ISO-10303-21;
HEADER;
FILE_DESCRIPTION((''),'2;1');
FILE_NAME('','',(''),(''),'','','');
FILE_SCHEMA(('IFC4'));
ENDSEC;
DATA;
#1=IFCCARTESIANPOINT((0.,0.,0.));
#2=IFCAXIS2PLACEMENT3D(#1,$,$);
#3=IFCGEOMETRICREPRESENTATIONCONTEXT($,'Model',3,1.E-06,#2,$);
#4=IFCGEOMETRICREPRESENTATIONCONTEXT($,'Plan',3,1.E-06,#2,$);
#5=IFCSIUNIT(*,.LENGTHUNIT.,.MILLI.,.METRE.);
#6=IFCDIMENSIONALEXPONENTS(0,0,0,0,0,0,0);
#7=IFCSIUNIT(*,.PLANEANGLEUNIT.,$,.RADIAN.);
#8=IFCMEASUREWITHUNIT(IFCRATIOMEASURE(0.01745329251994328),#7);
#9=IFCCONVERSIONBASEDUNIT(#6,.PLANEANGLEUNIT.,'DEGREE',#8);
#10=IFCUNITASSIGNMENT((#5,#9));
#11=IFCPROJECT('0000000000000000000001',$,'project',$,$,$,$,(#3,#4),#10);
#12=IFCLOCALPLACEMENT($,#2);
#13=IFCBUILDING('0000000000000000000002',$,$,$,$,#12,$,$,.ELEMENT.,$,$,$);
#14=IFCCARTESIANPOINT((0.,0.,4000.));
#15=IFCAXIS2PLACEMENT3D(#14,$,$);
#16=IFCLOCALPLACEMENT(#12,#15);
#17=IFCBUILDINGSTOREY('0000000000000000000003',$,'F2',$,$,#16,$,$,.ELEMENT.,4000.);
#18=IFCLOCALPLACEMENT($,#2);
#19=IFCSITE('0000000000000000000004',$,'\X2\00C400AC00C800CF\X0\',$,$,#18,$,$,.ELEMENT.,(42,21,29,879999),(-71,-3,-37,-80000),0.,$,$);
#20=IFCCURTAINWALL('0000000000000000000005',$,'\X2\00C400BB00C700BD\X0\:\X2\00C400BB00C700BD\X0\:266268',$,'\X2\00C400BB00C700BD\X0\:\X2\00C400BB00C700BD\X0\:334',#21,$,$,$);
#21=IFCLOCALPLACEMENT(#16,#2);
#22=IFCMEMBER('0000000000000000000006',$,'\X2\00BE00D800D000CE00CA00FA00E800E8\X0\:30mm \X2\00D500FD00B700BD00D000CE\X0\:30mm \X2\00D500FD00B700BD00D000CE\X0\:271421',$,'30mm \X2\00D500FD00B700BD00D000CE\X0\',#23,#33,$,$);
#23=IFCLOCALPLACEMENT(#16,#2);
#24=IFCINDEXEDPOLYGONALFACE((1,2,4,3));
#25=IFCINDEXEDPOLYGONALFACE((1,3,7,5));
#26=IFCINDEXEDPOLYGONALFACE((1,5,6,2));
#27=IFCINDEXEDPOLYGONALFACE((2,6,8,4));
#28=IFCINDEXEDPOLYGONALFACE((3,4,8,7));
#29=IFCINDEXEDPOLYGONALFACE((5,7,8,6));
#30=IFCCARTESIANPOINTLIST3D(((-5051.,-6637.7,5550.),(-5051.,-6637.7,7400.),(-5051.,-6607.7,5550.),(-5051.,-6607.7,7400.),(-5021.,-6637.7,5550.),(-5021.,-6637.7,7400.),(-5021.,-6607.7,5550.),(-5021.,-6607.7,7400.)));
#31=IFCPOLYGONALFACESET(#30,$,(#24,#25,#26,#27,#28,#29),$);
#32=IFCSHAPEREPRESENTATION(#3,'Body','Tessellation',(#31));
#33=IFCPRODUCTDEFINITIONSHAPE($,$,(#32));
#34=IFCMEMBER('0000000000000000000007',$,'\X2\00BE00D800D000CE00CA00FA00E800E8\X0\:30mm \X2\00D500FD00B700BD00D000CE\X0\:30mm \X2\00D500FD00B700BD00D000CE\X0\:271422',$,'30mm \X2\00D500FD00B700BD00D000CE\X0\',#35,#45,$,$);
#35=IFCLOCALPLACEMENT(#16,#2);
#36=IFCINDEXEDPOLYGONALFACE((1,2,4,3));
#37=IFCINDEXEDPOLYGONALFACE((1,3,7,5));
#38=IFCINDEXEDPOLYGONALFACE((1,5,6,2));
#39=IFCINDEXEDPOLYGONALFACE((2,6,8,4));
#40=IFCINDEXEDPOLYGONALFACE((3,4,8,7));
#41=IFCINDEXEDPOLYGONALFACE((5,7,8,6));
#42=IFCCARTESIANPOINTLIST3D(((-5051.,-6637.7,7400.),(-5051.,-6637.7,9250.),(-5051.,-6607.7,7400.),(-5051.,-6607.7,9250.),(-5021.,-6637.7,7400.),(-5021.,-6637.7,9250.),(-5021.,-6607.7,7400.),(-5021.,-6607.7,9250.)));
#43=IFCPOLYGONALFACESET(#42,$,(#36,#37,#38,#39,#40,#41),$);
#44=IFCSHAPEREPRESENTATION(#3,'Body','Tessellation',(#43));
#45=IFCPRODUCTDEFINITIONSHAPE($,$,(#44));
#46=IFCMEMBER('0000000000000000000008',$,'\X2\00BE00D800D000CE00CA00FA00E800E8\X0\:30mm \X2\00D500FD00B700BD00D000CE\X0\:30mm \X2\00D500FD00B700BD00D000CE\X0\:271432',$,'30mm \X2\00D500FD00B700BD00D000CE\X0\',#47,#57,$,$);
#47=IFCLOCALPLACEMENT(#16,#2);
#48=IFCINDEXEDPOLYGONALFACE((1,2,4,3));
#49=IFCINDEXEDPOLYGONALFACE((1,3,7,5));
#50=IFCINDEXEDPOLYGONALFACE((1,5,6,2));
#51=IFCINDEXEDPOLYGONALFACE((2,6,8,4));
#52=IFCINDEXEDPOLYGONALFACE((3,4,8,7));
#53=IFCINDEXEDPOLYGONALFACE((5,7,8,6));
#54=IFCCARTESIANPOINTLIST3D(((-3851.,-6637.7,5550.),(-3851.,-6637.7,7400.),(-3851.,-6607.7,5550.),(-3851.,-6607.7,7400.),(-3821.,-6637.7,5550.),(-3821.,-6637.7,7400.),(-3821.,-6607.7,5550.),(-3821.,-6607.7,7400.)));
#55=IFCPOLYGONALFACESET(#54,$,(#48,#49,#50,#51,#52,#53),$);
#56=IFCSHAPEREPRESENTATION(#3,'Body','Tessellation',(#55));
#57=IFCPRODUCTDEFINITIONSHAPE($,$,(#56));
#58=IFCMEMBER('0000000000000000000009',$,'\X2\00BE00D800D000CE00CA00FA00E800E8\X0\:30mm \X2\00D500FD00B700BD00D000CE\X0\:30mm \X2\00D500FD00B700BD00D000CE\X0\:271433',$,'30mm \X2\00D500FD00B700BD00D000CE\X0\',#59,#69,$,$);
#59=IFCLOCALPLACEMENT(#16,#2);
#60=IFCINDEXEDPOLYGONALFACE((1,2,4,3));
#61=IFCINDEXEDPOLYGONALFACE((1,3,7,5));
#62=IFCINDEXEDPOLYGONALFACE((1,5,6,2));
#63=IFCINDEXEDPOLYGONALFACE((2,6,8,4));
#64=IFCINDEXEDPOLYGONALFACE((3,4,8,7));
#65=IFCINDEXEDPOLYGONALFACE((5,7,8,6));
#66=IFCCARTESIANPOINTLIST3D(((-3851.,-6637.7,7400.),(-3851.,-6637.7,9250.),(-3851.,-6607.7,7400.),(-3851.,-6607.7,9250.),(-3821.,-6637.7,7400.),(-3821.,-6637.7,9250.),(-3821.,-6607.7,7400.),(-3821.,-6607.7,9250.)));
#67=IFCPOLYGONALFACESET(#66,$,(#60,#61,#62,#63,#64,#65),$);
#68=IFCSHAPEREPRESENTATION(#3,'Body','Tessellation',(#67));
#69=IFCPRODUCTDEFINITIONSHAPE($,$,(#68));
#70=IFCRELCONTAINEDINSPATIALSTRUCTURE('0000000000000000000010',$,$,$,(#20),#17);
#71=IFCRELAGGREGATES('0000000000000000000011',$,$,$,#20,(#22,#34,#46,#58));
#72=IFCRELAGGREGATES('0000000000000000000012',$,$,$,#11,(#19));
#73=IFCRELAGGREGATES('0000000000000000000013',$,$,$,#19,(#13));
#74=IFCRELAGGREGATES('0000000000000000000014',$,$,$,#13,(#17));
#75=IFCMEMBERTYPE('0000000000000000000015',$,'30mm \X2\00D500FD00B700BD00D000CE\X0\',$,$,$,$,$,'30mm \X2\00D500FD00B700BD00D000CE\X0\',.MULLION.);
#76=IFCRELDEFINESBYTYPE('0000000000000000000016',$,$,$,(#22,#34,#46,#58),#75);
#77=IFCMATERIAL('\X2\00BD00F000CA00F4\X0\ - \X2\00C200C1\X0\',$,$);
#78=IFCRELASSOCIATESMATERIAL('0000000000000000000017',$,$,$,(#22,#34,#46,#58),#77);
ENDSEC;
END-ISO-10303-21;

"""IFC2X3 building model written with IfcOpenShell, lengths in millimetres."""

from ifc_helpers import new_model, entity, si_unit, converted_unit, frame, origin, origin_2d_with_axis, place, context, project, spatial, rectangle, extrude, source, transform, mapped, material, type_object, type_shapes, element, aggregate, save


model = new_model("IFC2X3")

# Units and contexts
model_context = context("Model", 3, precision=1e-06, world=origin())
plan_context = context("Plan", 3, precision=1e-06, world=origin())
ifc_project = project(units=[si_unit("LENGTHUNIT", "METRE", prefix="MILLI"), converted_unit("PLANEANGLEUNIT", "DEGREE", entity("IfcRatioMeasure", 0.01745329251994328), si_unit("PLANEANGLEUNIT", "RADIAN"), dimensions=[0, 0, 0, 0, 0, 0, 0])], contexts=[model_context, plan_context])

# Site, building, storey
site_placement = place(None, origin())
site = spatial("IfcSite", under=ifc_project, at=site_placement, Name="Ä¬ÈÏ", CompositionType="ELEMENT", RefLatitude=(42, 21, 29, 879999), RefLongitude=(-71, -3, -37, -80000), RefElevation=0.0)
building_placement = place(None, origin())
building = spatial("IfcBuilding", under=site, at=building_placement, CompositionType="ELEMENT")
storey_placement = place(building_placement, frame((0.0, 0.0, 4000.0)))
storey = spatial("IfcBuildingStorey", under=building, at=storey_placement, Name="F2", CompositionType="ELEMENT", Elevation=4000.0)

# Curtain wall, members
curtain_wall_placement = place(storey_placement, origin())
curtain_wall = element("IfcCurtainWall", 1, at=curtain_wall_placement, inside=storey, Name="Ä»Ç½:Ä»Ç½:266268", ObjectType="Ä»Ç½:Ä»Ç½:334")
ifc_material_1 = material(Name="½ðÊô - ÂÁ")
placement_1 = place(building_placement, frame((0.0, 0.0, 11400.0)))
placement_2 = place(building_placement, frame((0.0, 0.0, 7700.0)))
member_type_1 = type_object("IfcMemberType", Name="30mm Õý·½ÐÎ", ElementType="30mm Õý·½ÐÎ", PredefinedType="MULLION")
shared_shape_1 = source(origin(), model_context, "Body", "SweptSolid", [
    extrude(rectangle(XDim=30.0, YDim=30.0, at=origin_2d_with_axis()), frame((0.0, 0.0, -1850.0), z_axis=(0.0, 0.0, 1.0), x_axis=(-1.0, 0.0, 0.0)), (0.0, 0.0, 1.0), 1850.0),
])
type_shapes(member_type_1, [shared_shape_1])
member_1_placement = place(placement_2, frame((-5036.0, -6622.7, 1850.0), z_axis=(0.0, 0.0, -1.0), x_axis=(1.0, 0.0, 0.0)))
member_1 = element("IfcMember", 2, at=member_1_placement, type_object=member_type_1, material=ifc_material_1, Name="¾ØÐÎÊúèè:30mm Õý·½ÐÎ:30mm Õý·½ÐÎ:271421", ObjectType="30mm Õý·½ÐÎ", context=model_context, shape_type="MappedRepresentation", body=[
    mapped(shared_shape_1, transform((0.0, 0.0, 0.0), scale=1.0)),
])
member_2_placement = place(placement_1, frame((-5036.0, -6622.7, 0.0), z_axis=(0.0, 0.0, -1.0), x_axis=(1.0, 0.0, 0.0)))
member_2 = element("IfcMember", 3, at=member_2_placement, type_object=member_type_1, material=ifc_material_1, Name="¾ØÐÎÊúèè:30mm Õý·½ÐÎ:30mm Õý·½ÐÎ:271422", ObjectType="30mm Õý·½ÐÎ", context=model_context, shape_type="MappedRepresentation", body=[
    mapped(shared_shape_1, transform((0.0, 0.0, 0.0), scale=1.0)),
])
member_3_placement = place(placement_2, frame((-3836.0, -6622.7, 1850.0), z_axis=(0.0, 0.0, -1.0), x_axis=(1.0, 0.0, 0.0)))
member_3 = element("IfcMember", 4, at=member_3_placement, type_object=member_type_1, material=ifc_material_1, Name="¾ØÐÎÊúèè:30mm Õý·½ÐÎ:30mm Õý·½ÐÎ:271432", ObjectType="30mm Õý·½ÐÎ", context=model_context, shape_type="MappedRepresentation", body=[
    mapped(shared_shape_1, transform((0.0, 0.0, 0.0), scale=1.0)),
])
member_4_placement = place(placement_1, frame((-3836.0, -6622.7, 0.0), z_axis=(0.0, 0.0, -1.0), x_axis=(1.0, 0.0, 0.0)))
member_4 = element("IfcMember", 5, at=member_4_placement, type_object=member_type_1, material=ifc_material_1, Name="¾ØÐÎÊúèè:30mm Õý·½ÐÎ:30mm Õý·½ÐÎ:271433", ObjectType="30mm Õý·½ÐÎ", context=model_context, shape_type="MappedRepresentation", body=[
    mapped(shared_shape_1, transform((0.0, 0.0, 0.0), scale=1.0)),
])
aggregate(curtain_wall, [member_1, member_2, member_3, member_4])

save(model, "model.ifc")
